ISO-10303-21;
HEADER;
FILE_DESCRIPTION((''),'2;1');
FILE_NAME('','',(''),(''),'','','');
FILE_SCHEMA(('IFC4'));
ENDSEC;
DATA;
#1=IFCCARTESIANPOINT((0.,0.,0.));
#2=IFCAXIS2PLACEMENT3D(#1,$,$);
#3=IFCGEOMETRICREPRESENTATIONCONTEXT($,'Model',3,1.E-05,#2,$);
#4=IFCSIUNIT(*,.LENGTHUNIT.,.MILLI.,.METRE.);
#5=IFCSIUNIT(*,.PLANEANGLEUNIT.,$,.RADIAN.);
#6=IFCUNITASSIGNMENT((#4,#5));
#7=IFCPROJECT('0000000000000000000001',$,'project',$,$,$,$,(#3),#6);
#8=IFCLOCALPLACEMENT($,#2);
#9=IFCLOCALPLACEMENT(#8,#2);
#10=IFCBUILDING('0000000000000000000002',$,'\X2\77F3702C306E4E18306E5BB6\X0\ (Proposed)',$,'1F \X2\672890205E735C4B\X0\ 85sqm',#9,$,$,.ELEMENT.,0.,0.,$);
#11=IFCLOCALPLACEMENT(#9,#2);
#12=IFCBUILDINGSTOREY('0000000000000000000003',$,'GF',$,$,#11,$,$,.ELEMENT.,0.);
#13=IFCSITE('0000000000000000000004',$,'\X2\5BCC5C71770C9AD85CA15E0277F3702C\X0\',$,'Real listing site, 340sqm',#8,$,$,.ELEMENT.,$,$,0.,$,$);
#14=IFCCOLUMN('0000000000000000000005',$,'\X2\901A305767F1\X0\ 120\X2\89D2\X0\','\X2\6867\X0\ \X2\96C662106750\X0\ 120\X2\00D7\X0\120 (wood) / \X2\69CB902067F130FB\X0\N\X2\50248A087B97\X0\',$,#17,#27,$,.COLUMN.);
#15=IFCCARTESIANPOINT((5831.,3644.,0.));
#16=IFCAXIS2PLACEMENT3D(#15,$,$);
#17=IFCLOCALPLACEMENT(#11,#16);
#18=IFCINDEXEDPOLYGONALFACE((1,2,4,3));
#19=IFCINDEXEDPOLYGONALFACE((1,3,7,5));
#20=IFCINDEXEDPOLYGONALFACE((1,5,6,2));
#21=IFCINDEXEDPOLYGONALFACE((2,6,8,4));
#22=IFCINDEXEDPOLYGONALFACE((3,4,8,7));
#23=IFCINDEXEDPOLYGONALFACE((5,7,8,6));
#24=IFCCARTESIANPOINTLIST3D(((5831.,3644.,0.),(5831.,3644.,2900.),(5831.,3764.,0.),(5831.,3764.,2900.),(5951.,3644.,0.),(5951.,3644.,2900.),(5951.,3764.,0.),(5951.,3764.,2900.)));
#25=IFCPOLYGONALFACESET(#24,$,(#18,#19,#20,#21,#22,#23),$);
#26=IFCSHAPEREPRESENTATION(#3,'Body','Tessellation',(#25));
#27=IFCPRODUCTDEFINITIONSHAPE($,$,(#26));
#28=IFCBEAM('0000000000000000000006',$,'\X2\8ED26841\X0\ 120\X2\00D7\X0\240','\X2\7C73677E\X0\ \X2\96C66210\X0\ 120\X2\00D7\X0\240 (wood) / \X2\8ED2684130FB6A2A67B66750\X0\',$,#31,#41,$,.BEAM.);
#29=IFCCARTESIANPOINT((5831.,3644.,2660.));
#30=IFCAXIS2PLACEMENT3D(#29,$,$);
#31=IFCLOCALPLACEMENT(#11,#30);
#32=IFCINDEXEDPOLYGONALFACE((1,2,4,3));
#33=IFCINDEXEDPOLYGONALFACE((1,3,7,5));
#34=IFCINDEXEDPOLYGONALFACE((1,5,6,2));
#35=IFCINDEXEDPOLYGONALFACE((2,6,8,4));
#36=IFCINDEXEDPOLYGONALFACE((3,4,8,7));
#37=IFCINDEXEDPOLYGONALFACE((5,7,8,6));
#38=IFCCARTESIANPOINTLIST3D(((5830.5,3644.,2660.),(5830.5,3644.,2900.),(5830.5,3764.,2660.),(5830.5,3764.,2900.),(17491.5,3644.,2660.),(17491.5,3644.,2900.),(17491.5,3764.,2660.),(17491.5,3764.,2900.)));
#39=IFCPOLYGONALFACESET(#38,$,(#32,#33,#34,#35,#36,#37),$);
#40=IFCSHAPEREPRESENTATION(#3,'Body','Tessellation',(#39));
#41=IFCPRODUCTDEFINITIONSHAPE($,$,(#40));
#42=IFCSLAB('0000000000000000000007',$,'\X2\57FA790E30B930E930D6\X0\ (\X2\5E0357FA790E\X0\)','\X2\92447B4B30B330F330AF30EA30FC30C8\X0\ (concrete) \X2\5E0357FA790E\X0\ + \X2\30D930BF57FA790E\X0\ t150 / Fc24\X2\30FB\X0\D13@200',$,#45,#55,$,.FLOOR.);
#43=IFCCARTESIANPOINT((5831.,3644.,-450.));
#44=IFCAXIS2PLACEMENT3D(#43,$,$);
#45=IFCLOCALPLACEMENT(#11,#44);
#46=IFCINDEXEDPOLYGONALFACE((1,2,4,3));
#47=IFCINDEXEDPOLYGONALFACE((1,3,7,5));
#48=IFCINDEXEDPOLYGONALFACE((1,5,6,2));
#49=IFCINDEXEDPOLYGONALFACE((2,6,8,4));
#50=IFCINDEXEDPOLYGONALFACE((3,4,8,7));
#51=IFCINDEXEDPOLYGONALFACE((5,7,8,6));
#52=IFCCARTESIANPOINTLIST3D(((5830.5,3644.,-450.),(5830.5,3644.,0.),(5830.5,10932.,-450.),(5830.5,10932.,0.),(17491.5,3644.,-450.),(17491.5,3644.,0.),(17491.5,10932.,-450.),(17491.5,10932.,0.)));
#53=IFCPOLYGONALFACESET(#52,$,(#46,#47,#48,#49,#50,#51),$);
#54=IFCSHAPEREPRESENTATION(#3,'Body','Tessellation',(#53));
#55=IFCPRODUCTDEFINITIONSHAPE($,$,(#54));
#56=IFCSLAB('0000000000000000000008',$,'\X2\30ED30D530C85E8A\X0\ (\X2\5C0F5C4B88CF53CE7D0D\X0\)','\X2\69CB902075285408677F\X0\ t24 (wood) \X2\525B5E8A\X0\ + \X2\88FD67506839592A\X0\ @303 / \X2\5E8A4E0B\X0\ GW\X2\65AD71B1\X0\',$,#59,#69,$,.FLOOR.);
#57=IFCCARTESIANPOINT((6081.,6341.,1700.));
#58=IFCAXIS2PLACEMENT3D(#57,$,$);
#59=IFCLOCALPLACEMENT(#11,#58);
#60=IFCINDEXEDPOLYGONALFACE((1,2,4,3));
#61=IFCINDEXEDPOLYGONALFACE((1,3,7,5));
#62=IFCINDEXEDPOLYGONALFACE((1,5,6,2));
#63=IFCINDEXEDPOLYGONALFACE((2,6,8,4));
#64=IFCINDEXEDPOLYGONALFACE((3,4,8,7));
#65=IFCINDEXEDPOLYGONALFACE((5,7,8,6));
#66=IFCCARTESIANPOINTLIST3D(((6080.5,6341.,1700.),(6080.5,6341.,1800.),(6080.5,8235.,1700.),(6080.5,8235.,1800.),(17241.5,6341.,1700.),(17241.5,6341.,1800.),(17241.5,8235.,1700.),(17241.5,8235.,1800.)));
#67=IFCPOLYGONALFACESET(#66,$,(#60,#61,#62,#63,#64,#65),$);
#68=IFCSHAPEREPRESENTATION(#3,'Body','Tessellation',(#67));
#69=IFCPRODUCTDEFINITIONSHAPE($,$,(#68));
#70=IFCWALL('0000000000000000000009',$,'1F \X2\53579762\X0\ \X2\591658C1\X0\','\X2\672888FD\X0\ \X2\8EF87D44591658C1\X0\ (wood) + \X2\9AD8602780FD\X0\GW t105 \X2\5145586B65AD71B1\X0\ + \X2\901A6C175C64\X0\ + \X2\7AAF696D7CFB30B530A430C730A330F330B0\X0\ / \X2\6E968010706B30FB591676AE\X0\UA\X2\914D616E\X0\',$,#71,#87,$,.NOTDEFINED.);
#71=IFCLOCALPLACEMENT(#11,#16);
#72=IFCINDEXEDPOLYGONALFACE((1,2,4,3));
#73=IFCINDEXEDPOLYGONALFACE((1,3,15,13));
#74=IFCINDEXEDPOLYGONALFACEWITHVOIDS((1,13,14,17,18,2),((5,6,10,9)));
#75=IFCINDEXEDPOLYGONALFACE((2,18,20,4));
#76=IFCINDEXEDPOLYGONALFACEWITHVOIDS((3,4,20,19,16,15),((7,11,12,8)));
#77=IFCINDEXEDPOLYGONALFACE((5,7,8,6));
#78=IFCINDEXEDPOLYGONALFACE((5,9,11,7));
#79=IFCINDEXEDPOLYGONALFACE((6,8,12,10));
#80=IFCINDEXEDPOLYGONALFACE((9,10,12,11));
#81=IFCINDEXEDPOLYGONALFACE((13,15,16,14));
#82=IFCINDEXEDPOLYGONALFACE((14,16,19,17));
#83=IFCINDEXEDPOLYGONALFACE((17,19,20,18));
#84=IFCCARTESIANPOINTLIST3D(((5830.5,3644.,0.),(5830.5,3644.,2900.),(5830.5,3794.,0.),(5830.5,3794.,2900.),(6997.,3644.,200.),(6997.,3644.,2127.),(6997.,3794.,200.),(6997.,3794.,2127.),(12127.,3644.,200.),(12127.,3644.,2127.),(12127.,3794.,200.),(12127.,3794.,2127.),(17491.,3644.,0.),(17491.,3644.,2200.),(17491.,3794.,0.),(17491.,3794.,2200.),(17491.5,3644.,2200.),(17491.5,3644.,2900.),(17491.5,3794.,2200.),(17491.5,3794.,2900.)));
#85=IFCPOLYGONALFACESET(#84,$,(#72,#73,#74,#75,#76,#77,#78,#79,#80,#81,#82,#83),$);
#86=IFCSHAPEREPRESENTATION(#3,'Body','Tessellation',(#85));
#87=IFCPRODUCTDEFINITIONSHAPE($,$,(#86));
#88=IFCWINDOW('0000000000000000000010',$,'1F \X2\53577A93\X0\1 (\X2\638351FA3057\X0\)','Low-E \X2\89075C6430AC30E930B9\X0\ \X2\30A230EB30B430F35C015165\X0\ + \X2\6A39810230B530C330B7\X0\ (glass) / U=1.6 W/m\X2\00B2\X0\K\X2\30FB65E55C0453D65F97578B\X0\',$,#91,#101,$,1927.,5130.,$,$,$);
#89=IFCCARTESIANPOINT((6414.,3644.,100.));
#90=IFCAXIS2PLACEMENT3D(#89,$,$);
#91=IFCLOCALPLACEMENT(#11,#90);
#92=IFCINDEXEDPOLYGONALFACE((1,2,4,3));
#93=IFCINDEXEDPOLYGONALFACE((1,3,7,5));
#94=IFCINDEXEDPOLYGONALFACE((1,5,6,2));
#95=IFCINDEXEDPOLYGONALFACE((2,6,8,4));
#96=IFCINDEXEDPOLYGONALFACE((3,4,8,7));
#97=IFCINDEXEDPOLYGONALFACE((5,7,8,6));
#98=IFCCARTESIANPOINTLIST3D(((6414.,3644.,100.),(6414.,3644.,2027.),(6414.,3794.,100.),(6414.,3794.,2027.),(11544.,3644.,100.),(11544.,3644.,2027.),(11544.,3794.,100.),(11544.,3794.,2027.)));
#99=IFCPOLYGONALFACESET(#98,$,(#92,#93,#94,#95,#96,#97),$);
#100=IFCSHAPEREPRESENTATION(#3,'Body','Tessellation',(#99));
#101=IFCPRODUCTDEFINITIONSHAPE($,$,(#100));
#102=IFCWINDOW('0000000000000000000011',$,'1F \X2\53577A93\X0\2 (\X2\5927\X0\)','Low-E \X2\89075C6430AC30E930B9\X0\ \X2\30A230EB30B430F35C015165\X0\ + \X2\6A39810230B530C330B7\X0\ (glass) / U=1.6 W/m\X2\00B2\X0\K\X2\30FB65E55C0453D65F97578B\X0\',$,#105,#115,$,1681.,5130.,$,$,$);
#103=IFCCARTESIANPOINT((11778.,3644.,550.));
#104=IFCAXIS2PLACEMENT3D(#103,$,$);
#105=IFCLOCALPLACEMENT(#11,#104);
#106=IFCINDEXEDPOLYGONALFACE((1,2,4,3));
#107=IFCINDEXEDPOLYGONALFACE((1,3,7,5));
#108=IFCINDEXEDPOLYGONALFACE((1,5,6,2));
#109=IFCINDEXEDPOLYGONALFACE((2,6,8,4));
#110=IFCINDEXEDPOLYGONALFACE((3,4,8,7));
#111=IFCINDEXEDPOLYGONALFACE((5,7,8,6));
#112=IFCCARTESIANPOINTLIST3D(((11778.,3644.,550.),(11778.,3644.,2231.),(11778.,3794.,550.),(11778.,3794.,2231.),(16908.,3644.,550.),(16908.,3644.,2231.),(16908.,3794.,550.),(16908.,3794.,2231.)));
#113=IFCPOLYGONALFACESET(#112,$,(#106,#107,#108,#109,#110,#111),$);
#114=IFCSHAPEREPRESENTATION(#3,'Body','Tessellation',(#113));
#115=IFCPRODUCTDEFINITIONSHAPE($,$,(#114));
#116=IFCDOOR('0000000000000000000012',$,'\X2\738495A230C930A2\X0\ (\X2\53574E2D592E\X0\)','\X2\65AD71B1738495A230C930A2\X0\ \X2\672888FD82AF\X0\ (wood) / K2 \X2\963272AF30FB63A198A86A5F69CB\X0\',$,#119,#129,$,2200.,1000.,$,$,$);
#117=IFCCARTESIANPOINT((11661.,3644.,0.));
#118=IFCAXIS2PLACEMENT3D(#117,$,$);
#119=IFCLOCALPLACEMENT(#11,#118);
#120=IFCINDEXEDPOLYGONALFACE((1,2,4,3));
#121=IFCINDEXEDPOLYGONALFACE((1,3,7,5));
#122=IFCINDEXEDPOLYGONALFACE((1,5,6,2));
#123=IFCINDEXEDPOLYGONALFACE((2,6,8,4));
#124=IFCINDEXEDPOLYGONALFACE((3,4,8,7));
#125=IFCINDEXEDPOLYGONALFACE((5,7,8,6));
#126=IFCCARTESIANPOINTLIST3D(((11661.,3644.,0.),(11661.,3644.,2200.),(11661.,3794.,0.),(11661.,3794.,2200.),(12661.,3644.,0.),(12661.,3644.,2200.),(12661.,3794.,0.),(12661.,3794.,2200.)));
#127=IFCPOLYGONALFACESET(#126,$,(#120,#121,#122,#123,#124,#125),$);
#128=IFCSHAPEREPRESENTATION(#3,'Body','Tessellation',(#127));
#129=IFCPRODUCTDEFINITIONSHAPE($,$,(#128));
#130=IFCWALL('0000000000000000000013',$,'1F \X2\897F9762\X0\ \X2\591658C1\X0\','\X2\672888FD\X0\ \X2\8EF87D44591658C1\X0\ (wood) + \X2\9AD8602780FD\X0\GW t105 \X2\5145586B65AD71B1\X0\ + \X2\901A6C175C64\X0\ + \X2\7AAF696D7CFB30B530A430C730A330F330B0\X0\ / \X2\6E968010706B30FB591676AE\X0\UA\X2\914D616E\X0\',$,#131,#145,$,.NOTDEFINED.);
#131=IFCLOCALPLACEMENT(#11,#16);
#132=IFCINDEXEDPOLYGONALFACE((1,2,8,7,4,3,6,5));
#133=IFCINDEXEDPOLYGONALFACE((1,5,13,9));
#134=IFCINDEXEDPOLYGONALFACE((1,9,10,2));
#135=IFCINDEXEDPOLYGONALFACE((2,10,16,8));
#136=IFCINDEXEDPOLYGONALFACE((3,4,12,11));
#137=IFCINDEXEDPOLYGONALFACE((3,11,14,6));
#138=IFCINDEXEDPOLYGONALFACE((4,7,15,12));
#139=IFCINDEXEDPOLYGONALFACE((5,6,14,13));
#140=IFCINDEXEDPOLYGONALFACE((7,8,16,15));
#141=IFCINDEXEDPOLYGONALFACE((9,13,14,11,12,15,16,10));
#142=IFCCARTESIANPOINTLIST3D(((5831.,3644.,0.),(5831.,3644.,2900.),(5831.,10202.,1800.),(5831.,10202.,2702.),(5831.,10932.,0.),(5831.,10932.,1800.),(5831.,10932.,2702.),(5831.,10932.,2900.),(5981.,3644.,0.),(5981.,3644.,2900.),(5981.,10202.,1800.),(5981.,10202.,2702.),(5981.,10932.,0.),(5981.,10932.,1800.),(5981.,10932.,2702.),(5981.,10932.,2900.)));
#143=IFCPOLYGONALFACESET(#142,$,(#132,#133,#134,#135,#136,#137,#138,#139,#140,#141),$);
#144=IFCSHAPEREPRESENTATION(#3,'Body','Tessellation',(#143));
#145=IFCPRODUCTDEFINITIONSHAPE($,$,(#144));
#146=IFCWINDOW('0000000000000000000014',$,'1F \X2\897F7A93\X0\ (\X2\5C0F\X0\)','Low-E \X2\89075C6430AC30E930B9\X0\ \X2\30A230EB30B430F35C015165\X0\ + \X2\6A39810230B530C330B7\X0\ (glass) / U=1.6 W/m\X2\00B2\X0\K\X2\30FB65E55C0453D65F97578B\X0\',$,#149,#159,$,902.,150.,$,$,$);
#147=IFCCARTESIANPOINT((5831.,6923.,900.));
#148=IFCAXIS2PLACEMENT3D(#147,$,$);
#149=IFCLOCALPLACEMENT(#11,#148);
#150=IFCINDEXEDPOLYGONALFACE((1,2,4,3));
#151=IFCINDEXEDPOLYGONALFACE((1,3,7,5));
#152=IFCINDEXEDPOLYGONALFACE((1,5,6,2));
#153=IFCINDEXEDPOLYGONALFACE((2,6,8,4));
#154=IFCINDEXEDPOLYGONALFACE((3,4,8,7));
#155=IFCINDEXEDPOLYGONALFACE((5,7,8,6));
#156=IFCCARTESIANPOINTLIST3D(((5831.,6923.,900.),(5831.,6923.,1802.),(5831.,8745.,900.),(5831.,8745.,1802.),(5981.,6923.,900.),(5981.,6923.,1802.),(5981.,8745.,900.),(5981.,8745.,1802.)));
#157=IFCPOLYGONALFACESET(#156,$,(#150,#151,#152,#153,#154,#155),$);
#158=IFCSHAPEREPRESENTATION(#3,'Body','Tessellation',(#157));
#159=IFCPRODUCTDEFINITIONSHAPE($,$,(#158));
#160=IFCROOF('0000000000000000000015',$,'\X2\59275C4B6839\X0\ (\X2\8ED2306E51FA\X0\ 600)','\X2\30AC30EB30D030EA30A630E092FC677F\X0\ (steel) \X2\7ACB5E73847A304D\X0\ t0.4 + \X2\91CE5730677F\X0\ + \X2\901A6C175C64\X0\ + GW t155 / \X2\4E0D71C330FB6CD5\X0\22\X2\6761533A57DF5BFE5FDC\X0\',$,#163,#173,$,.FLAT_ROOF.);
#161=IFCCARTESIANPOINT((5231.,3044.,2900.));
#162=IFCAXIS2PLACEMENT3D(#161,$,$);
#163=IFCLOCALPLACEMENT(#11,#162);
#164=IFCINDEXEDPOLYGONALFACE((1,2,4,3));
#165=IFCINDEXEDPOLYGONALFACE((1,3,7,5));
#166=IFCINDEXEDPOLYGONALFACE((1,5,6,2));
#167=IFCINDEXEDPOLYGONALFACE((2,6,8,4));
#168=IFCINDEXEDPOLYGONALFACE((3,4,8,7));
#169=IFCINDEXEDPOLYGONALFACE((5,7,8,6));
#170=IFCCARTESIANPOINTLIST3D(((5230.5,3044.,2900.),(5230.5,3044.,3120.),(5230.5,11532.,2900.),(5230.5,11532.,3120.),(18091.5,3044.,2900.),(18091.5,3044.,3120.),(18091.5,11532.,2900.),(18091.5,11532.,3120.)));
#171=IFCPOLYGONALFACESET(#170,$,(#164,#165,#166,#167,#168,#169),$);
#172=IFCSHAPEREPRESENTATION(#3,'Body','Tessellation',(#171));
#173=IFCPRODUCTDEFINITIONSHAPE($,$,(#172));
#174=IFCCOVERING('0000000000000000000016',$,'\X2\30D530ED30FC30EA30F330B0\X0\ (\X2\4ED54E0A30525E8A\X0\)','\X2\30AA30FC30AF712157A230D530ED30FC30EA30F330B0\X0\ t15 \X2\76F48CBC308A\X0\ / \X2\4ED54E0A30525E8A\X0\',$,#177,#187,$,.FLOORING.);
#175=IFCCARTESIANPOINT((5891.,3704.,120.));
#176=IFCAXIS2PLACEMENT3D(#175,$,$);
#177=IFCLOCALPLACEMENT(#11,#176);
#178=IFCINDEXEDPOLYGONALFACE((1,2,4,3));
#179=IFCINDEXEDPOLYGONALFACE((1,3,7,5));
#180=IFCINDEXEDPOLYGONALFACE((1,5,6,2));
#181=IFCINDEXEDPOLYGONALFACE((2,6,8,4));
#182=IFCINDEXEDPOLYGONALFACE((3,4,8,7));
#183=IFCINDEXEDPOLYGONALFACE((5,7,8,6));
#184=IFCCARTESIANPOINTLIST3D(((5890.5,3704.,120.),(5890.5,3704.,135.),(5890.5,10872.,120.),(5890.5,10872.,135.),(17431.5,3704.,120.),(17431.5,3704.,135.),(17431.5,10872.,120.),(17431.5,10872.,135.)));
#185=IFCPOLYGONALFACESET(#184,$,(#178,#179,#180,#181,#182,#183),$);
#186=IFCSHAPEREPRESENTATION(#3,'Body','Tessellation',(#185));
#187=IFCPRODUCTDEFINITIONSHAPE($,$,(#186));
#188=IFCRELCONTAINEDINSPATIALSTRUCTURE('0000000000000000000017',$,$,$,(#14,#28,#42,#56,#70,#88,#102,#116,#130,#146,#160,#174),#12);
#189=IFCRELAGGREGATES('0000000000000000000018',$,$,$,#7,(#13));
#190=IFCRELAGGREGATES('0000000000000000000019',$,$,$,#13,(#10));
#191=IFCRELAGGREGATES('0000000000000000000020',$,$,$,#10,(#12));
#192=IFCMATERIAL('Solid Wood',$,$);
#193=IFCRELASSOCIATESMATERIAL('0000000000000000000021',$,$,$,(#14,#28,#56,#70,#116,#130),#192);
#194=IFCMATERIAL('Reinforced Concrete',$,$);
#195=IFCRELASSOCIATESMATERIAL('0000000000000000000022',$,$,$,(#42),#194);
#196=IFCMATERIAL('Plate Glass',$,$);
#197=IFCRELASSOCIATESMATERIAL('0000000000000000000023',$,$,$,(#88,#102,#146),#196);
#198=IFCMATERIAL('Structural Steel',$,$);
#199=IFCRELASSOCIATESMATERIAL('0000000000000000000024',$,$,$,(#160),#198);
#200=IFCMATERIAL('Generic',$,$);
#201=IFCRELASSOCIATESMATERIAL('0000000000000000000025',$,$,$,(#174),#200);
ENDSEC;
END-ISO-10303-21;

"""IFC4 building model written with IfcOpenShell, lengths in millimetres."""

from ifc_helpers import new_model, si_unit, frame, frame_2d, origin, place, context, project, spatial, rectangle, extrude, material, element, fill, save


model = new_model("IFC4")

# Units and contexts
model_context = context("Model", 3, precision=1e-05, world=origin())
ifc_project = project(units=[si_unit("LENGTHUNIT", "METRE", prefix="MILLI"), si_unit("PLANEANGLEUNIT", "RADIAN")], contexts=[model_context])

# Site, building, storey
site_placement = place(None, origin())
site = spatial("IfcSite", under=ifc_project, at=site_placement, Name="富山県高岡市石瀬", ObjectType="Real listing site, 340sqm", CompositionType="ELEMENT", RefElevation=0.0)
building_placement = place(site_placement, origin())
building = spatial("IfcBuilding", under=site, at=building_placement, Name="石瀬の丘の家 (Proposed)", ObjectType="1F 木造平屋 85sqm", CompositionType="ELEMENT", ElevationOfRefHeight=0.0, ElevationOfTerrain=0.0)
storey_placement = place(building_placement, origin())
storey = spatial("IfcBuildingStorey", under=building, at=storey_placement, Name="GF", CompositionType="ELEMENT", Elevation=0.0)

# Column
ifc_material_1 = material(Name="Solid Wood")
column_1_placement = place(storey_placement, frame((5831.0, 3644.0, 0.0)))
element("IfcColumn", 1, at=column_1_placement, inside=storey, material=ifc_material_1, Name="通し柱 120角", Description="桧 集成材 120×120 (wood) / 構造柱・N値計算", PredefinedType="COLUMN", context=model_context, shape_type="SweptSolid", body=[
    extrude(rectangle(XDim=120.0, YDim=120.0, at=frame_2d((60.0, 60.0))), frame((5831.0, 3644.0, 0.0)), (0.0, 0.0, 1.0), 2900.0),
])

# Beam
beam_1_placement = place(storey_placement, frame((5831.0, 3644.0, 2660.0)))
element("IfcBeam", 2, at=beam_1_placement, inside=storey, material=ifc_material_1, Name="軒桁 120×240", Description="米松 集成 120×240 (wood) / 軒桁・横架材", PredefinedType="BEAM", context=model_context, shape_type="SweptSolid", body=[
    extrude(rectangle(XDim=11661.0, YDim=120.0, at=frame_2d((5830.0, 60.0))), frame((5831.0, 3644.0, 2660.0)), (0.0, 0.0, 1.0), 240.0),
])

# Slabs
ifc_material_2 = material(Name="Reinforced Concrete")
slab_1_placement = place(storey_placement, frame((5831.0, 3644.0, -450.0)))
element("IfcSlab", 3, at=slab_1_placement, inside=storey, material=ifc_material_2, Name="基礎スラブ (布基礎)", Description="鉄筋コンクリート (concrete) 布基礎 + ベタ基礎 t150 / Fc24・D13@200", PredefinedType="FLOOR", context=model_context, shape_type="SweptSolid", body=[
    extrude(rectangle(XDim=11661.0, YDim=7288.0, at=frame_2d((5830.0, 3644.0))), frame((5831.0, 3644.0, -450.0)), (0.0, 0.0, 1.0), 450.0),
])
slab_2_placement = place(storey_placement, frame((6081.0, 6341.0, 1700.0)))
element("IfcSlab", 4, at=slab_2_placement, inside=storey, material=ifc_material_1, Name="ロフト床 (小屋裏収納)", Description="構造用合板 t24 (wood) 剛床 + 製材根太 @303 / 床下 GW断熱", PredefinedType="FLOOR", context=model_context, shape_type="SweptSolid", body=[
    extrude(rectangle(XDim=11161.0, YDim=1894.0, at=frame_2d((5580.0, 947.0))), frame((6081.0, 6341.0, 1700.0)), (0.0, 0.0, 1.0), 100.0),
])

# Wall, openings, windows, door
wall_1_placement = place(storey_placement, frame((5831.0, 3644.0, 0.0)))
wall_1 = element("IfcWall", 5, at=wall_1_placement, inside=storey, material=ifc_material_1, Name="1F 南面 外壁", Description="木製 軸組外壁 (wood) + 高性能GW t105 充填断熱 + 通気層 + 窯業系サイディング / 準耐火・外皮UA配慮", PredefinedType="NOTDEFINED", context=model_context, shape_type="SweptSolid", body=[
    extrude(rectangle(XDim=11661.0, YDim=150.0, at=frame_2d((5830.0, 75.0))), frame((5831.0, 3644.0, 0.0)), (0.0, 0.0, 1.0), 2900.0),
])
opening_1_placement = place(storey_placement, frame((6414.0, 3644.0, 100.0)))
opening_1 = element("IfcOpeningElement", 6, at=opening_1_placement, cuts=wall_1, PredefinedType="NOTDEFINED", context=model_context, shape_type="SweptSolid", body=[
    extrude(rectangle(XDim=5130.0, YDim=150.0, at=frame_2d((2565.0, 75.0))), frame((6414.0, 3644.0, 100.0)), (0.0, 0.0, 1.0), 1927.0),
])
opening_2_placement = place(storey_placement, frame((11778.0, 3644.0, 550.0)))
opening_2 = element("IfcOpeningElement", 7, at=opening_2_placement, cuts=wall_1, PredefinedType="NOTDEFINED", context=model_context, shape_type="SweptSolid", body=[
    extrude(rectangle(XDim=5130.0, YDim=150.0, at=frame_2d((2565.0, 75.0))), frame((11778.0, 3644.0, 550.0)), (0.0, 0.0, 1.0), 1681.0),
])
opening_3_placement = place(storey_placement, frame((11661.0, 3644.0, 0.0)))
opening_3 = element("IfcOpeningElement", 8, at=opening_3_placement, cuts=wall_1, PredefinedType="NOTDEFINED", context=model_context, shape_type="SweptSolid", body=[
    extrude(rectangle(XDim=1000.0, YDim=150.0, at=frame_2d((500.0, 75.0))), frame((11661.0, 3644.0, 0.0)), (0.0, 0.0, 1.0), 2200.0),
])
ifc_material_3 = material(Name="Plate Glass")
window_1_placement = place(storey_placement, frame((6414.0, 3644.0, 100.0)))
window_1 = element("IfcWindow", 9, at=window_1_placement, inside=storey, material=ifc_material_3, Name="1F 南窓1 (掃出し)", Description="Low-E 複層ガラス アルゴン封入 + 樹脂サッシ (glass) / U=1.6 W/m²K・日射取得型", OverallHeight=1927.0, OverallWidth=5130.0, context=model_context, shape_type="SweptSolid", body=[
    extrude(rectangle(XDim=5130.0, YDim=150.0, at=frame_2d((2565.0, 75.0))), frame((6414.0, 3644.0, 100.0)), (0.0, 0.0, 1.0), 1927.0),
])
fill(opening_1, window_1)
window_2_placement = place(storey_placement, frame((11778.0, 3644.0, 550.0)))
window_2 = element("IfcWindow", 10, at=window_2_placement, inside=storey, material=ifc_material_3, Name="1F 南窓2 (大)", Description="Low-E 複層ガラス アルゴン封入 + 樹脂サッシ (glass) / U=1.6 W/m²K・日射取得型", OverallHeight=1681.0, OverallWidth=5130.0, context=model_context, shape_type="SweptSolid", body=[
    extrude(rectangle(XDim=5130.0, YDim=150.0, at=frame_2d((2565.0, 75.0))), frame((11778.0, 3644.0, 550.0)), (0.0, 0.0, 1.0), 1681.0),
])
fill(opening_2, window_2)
door_placement = place(storey_placement, frame((11661.0, 3644.0, 0.0)))
door = element("IfcDoor", 11, at=door_placement, inside=storey, material=ifc_material_1, Name="玄関ドア (南中央)", Description="断熱玄関ドア 木製芯 (wood) / K2 防犯・採風機構", OverallHeight=2200.0, OverallWidth=1000.0, context=model_context, shape_type="SweptSolid", body=[
    extrude(rectangle(XDim=1000.0, YDim=150.0, at=frame_2d((500.0, 75.0))), frame((11661.0, 3644.0, 0.0)), (0.0, 0.0, 1.0), 2200.0),
])
fill(opening_3, door)

# Wall, opening, window
wall_2_placement = place(storey_placement, frame((5831.0, 3644.0, 0.0)))
wall_2 = element("IfcWall", 12, at=wall_2_placement, inside=storey, material=ifc_material_1, Name="1F 西面 外壁", Description="木製 軸組外壁 (wood) + 高性能GW t105 充填断熱 + 通気層 + 窯業系サイディング / 準耐火・外皮UA配慮", PredefinedType="NOTDEFINED", context=model_context, shape_type="SweptSolid", body=[
    extrude(rectangle(XDim=150.0, YDim=7288.0, at=frame_2d((75.0, 3644.0))), frame((5831.0, 3644.0, 0.0)), (0.0, 0.0, 1.0), 2900.0),
])
opening_4_placement = place(storey_placement, frame((5831.0, 6923.0, 900.0)))
opening_4 = element("IfcOpeningElement", 13, at=opening_4_placement, cuts=wall_2, PredefinedType="NOTDEFINED", context=model_context, shape_type="SweptSolid", body=[
    extrude(rectangle(XDim=150.0, YDim=1822.0, at=frame_2d((75.0, 911.0))), frame((5831.0, 6923.0, 900.0)), (0.0, 0.0, 1.0), 902.0),
])
window_3_placement = place(storey_placement, frame((5831.0, 6923.0, 900.0)))
window_3 = element("IfcWindow", 14, at=window_3_placement, inside=storey, material=ifc_material_3, Name="1F 西窓 (小)", Description="Low-E 複層ガラス アルゴン封入 + 樹脂サッシ (glass) / U=1.6 W/m²K・日射取得型", OverallHeight=902.0, OverallWidth=150.0, context=model_context, shape_type="SweptSolid", body=[
    extrude(rectangle(XDim=150.0, YDim=1822.0, at=frame_2d((75.0, 911.0))), frame((5831.0, 6923.0, 900.0)), (0.0, 0.0, 1.0), 902.0),
])
fill(opening_4, window_3)

# Roof
ifc_material_4 = material(Name="Structural Steel")
roof_placement = place(storey_placement, frame((5231.0, 3044.0, 2900.0)))
element("IfcRoof", 15, at=roof_placement, inside=storey, material=ifc_material_4, Name="大屋根 (軒の出 600)", Description="ガルバリウム鋼板 (steel) 立平葺き t0.4 + 野地板 + 通気層 + GW t155 / 不燃・法22条区域対応", PredefinedType="FLAT_ROOF", context=model_context, shape_type="SweptSolid", body=[
    extrude(rectangle(XDim=12861.0, YDim=8488.0, at=frame_2d((6430.0, 4244.0))), frame((5231.0, 3044.0, 2900.0)), (0.0, 0.0, 1.0), 220.0),
])

# Covering
ifc_material_5 = material(Name="Generic")
covering_1_placement = place(storey_placement, frame((5891.0, 3704.0, 120.0)))
element("IfcCovering", 16, at=covering_1_placement, inside=storey, material=ifc_material_5, Name="フローリング (仕上げ床)", Description="オーク無垢フローリング t15 直貼り / 仕上げ床", PredefinedType="FLOORING", context=model_context, shape_type="SweptSolid", body=[
    extrude(rectangle(XDim=11541.0, YDim=7168.0, at=frame_2d((5770.0, 3584.0))), frame((5891.0, 3704.0, 120.0)), (0.0, 0.0, 1.0), 15.0),
])

save(model, "model.ifc")
